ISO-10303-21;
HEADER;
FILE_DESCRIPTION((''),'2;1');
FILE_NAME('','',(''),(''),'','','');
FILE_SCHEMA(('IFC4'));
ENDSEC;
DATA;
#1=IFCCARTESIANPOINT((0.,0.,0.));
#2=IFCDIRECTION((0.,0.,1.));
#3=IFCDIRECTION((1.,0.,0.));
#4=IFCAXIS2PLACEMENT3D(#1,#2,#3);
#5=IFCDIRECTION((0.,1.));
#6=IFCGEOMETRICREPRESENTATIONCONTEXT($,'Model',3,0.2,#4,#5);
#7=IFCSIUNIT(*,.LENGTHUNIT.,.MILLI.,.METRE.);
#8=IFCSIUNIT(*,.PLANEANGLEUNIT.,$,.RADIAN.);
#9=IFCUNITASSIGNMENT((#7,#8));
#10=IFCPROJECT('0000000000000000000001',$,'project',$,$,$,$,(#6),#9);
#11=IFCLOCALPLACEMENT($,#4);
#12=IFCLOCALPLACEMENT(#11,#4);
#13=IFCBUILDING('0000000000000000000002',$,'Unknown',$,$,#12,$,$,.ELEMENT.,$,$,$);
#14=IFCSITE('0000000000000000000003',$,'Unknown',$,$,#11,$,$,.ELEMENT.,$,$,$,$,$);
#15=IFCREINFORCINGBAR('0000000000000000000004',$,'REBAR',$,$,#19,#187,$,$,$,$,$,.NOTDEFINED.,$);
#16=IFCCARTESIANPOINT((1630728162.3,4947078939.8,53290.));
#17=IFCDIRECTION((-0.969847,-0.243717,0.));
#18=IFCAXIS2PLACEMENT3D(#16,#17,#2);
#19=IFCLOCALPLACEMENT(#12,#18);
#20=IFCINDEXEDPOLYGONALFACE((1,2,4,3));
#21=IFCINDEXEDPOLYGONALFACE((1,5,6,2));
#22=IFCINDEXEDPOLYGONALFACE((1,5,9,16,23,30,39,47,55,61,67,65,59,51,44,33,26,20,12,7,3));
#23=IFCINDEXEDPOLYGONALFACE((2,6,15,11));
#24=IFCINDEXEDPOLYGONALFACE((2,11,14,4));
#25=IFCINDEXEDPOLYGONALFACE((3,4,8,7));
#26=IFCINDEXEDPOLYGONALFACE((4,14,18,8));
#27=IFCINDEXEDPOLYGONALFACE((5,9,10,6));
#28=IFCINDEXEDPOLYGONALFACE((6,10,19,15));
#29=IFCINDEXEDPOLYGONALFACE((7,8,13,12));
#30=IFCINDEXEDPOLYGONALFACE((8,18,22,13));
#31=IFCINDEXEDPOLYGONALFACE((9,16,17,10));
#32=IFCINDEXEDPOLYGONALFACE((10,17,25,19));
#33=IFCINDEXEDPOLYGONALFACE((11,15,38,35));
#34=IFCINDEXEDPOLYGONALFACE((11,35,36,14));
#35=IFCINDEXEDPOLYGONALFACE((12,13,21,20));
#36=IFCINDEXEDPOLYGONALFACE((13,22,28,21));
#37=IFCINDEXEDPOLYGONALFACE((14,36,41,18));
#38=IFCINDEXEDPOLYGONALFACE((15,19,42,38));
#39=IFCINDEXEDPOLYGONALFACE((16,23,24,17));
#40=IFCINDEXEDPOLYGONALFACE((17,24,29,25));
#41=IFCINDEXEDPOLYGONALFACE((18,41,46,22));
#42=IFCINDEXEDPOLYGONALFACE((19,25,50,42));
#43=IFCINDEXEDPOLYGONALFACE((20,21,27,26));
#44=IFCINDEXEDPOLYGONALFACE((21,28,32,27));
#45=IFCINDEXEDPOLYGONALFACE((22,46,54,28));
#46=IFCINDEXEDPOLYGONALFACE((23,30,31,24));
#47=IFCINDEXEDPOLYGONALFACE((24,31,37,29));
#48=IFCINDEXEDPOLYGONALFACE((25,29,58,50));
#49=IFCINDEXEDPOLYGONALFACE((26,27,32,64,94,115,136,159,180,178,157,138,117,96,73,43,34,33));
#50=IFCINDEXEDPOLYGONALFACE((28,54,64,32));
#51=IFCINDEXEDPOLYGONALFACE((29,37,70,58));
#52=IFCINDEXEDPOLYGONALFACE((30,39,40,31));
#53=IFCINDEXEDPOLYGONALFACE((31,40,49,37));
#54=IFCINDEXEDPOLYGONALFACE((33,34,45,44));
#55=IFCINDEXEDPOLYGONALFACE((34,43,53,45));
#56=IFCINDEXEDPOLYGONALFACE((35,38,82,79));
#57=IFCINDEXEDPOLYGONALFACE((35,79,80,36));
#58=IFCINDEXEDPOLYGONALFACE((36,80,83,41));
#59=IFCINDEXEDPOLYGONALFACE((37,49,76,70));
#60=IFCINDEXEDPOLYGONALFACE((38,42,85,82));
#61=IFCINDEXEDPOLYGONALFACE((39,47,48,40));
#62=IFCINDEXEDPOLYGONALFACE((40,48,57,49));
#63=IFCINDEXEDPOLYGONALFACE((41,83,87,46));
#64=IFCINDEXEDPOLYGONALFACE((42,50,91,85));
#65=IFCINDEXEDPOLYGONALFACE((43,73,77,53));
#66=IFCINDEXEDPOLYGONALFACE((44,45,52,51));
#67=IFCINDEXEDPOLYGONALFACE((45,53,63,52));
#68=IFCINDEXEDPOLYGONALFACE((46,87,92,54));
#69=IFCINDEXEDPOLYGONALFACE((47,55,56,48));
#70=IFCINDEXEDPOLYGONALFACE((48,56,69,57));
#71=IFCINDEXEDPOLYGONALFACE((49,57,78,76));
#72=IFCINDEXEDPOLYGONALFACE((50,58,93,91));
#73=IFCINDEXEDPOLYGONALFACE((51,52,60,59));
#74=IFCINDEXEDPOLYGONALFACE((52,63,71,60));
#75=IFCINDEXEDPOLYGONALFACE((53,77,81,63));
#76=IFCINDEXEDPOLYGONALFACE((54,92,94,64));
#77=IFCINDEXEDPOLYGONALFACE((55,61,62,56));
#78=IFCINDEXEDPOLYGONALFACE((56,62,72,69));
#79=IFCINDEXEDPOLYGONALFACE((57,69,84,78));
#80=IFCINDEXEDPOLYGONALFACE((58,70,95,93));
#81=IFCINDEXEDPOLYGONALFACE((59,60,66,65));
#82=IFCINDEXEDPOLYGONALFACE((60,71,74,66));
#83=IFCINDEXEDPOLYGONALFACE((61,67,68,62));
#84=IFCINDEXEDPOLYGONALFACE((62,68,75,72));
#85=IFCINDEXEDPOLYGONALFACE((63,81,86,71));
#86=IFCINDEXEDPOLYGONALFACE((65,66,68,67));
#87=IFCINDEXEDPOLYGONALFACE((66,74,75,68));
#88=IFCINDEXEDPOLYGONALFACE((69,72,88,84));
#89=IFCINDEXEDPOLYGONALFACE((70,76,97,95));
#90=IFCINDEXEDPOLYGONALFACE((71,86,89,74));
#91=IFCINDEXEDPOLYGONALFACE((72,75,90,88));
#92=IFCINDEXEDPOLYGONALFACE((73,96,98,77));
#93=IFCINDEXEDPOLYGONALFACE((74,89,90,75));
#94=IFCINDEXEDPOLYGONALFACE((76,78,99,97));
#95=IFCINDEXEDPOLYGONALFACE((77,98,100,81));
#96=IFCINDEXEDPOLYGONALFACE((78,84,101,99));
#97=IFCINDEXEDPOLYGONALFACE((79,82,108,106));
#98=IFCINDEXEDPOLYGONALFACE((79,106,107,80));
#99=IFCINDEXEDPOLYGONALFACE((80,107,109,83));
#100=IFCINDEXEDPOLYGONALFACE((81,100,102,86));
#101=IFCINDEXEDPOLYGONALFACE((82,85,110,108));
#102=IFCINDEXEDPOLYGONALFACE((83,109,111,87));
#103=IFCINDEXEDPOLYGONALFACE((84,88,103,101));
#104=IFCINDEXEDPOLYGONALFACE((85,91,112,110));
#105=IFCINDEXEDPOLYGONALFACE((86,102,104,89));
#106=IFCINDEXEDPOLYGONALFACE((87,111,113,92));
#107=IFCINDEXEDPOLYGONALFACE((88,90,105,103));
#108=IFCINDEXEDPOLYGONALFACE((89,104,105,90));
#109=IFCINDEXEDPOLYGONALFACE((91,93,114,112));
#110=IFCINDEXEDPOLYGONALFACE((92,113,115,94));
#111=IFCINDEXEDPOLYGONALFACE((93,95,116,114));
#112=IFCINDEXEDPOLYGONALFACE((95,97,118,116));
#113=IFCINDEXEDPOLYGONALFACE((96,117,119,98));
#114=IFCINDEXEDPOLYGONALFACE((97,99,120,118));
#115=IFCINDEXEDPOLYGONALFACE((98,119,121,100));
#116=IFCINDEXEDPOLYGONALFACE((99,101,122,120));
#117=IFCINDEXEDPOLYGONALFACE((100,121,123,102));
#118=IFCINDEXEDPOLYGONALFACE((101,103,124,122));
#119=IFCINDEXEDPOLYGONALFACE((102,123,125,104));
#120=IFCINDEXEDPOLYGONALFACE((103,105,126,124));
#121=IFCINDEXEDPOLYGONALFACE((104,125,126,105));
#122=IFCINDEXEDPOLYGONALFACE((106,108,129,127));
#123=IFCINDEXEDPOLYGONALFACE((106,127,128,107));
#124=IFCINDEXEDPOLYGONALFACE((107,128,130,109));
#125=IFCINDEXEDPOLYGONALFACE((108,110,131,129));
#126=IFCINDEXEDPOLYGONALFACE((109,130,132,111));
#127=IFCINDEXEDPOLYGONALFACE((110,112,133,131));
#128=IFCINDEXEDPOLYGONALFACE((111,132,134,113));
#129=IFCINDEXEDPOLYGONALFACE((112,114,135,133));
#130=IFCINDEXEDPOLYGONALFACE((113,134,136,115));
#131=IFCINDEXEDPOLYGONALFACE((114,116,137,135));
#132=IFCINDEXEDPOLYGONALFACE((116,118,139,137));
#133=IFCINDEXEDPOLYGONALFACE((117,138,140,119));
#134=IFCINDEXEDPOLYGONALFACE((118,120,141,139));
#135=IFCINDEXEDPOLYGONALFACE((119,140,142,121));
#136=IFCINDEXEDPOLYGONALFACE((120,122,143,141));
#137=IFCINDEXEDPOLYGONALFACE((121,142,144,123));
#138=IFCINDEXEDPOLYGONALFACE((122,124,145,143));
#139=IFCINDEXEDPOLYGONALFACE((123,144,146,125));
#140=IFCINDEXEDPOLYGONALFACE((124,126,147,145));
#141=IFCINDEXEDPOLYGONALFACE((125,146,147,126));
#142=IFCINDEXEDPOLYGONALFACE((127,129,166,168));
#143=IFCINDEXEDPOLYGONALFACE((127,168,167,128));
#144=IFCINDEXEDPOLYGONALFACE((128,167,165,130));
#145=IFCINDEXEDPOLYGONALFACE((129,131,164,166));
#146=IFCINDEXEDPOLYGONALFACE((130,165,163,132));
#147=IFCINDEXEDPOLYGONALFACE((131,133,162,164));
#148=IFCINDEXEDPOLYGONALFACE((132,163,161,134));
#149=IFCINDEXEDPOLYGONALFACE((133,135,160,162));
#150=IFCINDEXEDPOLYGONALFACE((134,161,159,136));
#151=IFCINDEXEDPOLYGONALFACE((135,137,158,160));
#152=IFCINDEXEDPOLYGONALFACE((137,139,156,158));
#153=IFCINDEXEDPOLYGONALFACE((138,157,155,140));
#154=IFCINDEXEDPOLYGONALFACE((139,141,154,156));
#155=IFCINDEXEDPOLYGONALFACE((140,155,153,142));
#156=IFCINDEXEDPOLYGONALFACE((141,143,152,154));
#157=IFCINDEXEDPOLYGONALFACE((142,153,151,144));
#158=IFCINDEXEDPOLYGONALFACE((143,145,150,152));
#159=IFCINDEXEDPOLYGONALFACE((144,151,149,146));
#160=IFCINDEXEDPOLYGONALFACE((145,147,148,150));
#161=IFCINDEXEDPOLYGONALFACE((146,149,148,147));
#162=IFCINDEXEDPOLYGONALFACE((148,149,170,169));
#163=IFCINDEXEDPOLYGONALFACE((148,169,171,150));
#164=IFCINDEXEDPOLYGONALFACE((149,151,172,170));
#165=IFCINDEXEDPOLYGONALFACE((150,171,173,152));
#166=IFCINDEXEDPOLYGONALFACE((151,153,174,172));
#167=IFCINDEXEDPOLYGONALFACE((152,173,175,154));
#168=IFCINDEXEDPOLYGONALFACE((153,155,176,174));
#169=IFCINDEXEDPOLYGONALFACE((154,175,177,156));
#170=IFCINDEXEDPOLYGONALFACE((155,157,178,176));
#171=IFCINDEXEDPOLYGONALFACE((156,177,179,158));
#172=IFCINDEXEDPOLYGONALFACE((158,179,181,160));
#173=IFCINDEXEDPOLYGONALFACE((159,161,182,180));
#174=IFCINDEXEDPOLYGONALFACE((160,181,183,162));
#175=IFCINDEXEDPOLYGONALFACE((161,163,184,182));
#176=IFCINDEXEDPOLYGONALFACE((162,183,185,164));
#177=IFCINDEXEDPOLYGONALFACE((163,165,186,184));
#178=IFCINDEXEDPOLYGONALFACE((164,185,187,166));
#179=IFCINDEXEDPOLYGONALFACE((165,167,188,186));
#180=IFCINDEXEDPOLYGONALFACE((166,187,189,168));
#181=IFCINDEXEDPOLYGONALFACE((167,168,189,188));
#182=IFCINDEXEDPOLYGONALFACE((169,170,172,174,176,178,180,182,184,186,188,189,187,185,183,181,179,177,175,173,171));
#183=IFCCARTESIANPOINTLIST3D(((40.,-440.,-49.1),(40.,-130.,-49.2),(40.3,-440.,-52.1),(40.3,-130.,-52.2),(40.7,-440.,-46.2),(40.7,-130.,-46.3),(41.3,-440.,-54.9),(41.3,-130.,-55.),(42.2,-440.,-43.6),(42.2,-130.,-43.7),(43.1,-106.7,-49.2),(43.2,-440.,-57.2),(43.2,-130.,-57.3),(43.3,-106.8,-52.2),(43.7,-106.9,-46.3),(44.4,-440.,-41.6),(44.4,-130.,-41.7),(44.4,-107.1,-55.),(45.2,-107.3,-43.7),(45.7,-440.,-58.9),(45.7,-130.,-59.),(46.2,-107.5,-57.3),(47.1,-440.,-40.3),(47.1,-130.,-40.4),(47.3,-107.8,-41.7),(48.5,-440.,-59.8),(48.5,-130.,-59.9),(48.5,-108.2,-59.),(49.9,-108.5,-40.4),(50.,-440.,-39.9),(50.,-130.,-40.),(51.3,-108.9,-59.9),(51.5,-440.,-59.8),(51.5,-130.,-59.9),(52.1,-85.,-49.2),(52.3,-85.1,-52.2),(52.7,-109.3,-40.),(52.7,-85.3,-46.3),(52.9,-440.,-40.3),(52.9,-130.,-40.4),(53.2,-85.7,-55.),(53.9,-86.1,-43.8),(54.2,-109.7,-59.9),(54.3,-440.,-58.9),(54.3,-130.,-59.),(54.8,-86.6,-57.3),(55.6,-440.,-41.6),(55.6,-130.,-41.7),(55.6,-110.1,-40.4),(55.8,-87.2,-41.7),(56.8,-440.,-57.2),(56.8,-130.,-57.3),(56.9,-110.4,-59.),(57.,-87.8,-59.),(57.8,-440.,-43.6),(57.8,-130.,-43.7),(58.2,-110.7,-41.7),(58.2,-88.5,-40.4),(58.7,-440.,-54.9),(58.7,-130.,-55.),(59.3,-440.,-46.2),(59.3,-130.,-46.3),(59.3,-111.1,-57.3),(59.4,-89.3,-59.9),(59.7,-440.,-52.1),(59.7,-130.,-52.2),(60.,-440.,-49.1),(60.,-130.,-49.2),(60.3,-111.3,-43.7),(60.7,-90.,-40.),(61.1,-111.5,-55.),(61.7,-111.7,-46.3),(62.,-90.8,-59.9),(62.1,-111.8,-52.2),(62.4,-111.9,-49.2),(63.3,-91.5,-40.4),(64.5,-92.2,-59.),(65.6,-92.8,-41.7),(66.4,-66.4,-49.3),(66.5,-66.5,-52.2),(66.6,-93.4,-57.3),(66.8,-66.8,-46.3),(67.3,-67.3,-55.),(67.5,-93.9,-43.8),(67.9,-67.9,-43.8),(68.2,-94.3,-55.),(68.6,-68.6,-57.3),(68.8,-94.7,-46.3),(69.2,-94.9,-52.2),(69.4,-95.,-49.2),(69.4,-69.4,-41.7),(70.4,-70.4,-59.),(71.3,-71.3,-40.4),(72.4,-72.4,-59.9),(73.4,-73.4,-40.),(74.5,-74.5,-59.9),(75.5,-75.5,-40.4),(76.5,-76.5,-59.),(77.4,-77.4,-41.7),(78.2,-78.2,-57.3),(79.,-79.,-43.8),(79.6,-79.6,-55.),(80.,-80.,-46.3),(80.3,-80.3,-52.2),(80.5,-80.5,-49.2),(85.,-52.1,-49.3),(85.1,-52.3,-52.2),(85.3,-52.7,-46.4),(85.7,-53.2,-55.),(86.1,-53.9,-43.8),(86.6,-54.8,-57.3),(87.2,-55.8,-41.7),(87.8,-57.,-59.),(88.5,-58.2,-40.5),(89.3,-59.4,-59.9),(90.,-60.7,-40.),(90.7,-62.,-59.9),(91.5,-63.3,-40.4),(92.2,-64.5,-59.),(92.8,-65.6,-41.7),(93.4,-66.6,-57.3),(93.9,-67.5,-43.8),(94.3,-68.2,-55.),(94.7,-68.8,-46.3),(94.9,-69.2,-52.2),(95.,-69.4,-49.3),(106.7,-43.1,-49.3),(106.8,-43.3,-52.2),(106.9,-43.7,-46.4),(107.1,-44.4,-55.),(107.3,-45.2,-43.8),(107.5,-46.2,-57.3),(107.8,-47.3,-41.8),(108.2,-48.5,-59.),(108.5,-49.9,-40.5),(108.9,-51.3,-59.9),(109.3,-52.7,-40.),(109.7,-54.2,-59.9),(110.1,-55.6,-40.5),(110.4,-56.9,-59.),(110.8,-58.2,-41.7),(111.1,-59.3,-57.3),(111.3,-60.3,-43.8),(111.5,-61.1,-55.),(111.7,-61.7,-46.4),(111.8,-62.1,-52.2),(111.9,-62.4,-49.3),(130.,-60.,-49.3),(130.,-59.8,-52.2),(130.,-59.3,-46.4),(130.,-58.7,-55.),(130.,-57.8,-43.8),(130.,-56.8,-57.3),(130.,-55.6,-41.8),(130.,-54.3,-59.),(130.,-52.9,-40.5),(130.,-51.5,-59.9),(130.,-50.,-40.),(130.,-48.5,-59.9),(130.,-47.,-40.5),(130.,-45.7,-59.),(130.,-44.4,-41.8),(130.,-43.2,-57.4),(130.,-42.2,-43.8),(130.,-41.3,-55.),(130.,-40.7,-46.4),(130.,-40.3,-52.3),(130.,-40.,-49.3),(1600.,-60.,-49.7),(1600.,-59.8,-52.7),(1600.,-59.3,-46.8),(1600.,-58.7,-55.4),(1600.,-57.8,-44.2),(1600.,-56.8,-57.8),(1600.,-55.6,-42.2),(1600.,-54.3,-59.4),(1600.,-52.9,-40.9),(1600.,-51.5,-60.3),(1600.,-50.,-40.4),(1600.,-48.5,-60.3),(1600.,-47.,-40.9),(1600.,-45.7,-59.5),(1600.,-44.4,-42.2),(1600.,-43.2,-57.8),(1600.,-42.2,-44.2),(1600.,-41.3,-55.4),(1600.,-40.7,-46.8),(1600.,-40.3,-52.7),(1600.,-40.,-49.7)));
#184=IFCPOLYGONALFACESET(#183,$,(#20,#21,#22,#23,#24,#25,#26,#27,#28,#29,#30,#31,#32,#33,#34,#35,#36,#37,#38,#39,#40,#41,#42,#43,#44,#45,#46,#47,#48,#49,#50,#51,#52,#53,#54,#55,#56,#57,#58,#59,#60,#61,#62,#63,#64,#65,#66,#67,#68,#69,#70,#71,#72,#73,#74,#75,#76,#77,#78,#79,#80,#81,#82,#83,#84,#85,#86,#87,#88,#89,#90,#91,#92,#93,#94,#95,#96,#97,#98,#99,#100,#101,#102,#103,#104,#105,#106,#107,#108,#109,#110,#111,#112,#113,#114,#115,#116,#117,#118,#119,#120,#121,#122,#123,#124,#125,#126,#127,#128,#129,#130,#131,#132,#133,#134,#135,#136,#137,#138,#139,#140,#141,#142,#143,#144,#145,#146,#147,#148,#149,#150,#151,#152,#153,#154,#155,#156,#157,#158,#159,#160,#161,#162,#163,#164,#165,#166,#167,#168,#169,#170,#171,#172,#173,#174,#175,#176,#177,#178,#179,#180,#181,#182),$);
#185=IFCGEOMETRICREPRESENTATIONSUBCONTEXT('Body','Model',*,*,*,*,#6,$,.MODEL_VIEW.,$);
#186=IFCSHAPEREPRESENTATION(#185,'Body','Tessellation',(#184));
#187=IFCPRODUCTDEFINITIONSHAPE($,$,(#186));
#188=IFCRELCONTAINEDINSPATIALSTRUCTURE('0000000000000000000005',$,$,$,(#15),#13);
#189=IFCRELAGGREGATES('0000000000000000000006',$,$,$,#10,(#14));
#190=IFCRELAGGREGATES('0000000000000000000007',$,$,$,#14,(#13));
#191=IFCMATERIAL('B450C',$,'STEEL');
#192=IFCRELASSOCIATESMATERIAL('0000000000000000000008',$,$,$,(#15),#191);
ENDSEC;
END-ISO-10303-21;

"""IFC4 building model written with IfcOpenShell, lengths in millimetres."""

from ifc_helpers import new_model, entity, si_unit, direction, frame, origin_with_axes, place, context, subcontext, project, spatial, material, element, save


model = new_model("IFC4")

# Units and contexts
model_context = context("Model", 3, precision=0.2, world=origin_with_axes(), true_north=direction((0.0, 1.0)))
body_context = subcontext(model_context, "Body", "Model", "MODEL_VIEW")
ifc_project = project(units=[si_unit("LENGTHUNIT", "METRE", prefix="MILLI"), si_unit("PLANEANGLEUNIT", "RADIAN")], contexts=[model_context])

# Site, building
site_placement = place(None, origin_with_axes())
site = spatial("IfcSite", under=ifc_project, at=site_placement, Name="Unknown", CompositionType="ELEMENT")
building_placement = place(site_placement, origin_with_axes())
building = spatial("IfcBuilding", under=site, at=building_placement, Name="Unknown", CompositionType="ELEMENT")

# Reinforcing bar
ifc_material = material(Name="B450C", Category="STEEL")
reinforcing_bar_1_placement = place(building_placement, frame((1630728162.3, 4947078939.8, 53290.0), z_axis=(-0.969847, -0.243717, 0.0), x_axis=(0.0, 0.0, 1.0)))
element("IfcReinforcingBar", 1, at=reinforcing_bar_1_placement, inside=building, material=ifc_material, Name="REBAR", PredefinedType="NOTDEFINED", context=body_context, shape_type="AdvancedSweptSolid", body=[
    entity("IfcSweptDiskSolid", entity("IfcIndexedPolyCurve", entity("IfcCartesianPointList3D", [[50.0, -440.0, -49.9], [50.0, -130.0, -50.0], [73.4, -73.4, -50.0], [130.0, -50.0, -50.0], [1600.0, -50.0, -50.4]]), [entity("IfcLineIndex", [1, 2]), entity("IfcArcIndex", [2, 3, 4]), entity("IfcLineIndex", [4, 5])]), 10.0),
])

save(model, "model.ifc")
